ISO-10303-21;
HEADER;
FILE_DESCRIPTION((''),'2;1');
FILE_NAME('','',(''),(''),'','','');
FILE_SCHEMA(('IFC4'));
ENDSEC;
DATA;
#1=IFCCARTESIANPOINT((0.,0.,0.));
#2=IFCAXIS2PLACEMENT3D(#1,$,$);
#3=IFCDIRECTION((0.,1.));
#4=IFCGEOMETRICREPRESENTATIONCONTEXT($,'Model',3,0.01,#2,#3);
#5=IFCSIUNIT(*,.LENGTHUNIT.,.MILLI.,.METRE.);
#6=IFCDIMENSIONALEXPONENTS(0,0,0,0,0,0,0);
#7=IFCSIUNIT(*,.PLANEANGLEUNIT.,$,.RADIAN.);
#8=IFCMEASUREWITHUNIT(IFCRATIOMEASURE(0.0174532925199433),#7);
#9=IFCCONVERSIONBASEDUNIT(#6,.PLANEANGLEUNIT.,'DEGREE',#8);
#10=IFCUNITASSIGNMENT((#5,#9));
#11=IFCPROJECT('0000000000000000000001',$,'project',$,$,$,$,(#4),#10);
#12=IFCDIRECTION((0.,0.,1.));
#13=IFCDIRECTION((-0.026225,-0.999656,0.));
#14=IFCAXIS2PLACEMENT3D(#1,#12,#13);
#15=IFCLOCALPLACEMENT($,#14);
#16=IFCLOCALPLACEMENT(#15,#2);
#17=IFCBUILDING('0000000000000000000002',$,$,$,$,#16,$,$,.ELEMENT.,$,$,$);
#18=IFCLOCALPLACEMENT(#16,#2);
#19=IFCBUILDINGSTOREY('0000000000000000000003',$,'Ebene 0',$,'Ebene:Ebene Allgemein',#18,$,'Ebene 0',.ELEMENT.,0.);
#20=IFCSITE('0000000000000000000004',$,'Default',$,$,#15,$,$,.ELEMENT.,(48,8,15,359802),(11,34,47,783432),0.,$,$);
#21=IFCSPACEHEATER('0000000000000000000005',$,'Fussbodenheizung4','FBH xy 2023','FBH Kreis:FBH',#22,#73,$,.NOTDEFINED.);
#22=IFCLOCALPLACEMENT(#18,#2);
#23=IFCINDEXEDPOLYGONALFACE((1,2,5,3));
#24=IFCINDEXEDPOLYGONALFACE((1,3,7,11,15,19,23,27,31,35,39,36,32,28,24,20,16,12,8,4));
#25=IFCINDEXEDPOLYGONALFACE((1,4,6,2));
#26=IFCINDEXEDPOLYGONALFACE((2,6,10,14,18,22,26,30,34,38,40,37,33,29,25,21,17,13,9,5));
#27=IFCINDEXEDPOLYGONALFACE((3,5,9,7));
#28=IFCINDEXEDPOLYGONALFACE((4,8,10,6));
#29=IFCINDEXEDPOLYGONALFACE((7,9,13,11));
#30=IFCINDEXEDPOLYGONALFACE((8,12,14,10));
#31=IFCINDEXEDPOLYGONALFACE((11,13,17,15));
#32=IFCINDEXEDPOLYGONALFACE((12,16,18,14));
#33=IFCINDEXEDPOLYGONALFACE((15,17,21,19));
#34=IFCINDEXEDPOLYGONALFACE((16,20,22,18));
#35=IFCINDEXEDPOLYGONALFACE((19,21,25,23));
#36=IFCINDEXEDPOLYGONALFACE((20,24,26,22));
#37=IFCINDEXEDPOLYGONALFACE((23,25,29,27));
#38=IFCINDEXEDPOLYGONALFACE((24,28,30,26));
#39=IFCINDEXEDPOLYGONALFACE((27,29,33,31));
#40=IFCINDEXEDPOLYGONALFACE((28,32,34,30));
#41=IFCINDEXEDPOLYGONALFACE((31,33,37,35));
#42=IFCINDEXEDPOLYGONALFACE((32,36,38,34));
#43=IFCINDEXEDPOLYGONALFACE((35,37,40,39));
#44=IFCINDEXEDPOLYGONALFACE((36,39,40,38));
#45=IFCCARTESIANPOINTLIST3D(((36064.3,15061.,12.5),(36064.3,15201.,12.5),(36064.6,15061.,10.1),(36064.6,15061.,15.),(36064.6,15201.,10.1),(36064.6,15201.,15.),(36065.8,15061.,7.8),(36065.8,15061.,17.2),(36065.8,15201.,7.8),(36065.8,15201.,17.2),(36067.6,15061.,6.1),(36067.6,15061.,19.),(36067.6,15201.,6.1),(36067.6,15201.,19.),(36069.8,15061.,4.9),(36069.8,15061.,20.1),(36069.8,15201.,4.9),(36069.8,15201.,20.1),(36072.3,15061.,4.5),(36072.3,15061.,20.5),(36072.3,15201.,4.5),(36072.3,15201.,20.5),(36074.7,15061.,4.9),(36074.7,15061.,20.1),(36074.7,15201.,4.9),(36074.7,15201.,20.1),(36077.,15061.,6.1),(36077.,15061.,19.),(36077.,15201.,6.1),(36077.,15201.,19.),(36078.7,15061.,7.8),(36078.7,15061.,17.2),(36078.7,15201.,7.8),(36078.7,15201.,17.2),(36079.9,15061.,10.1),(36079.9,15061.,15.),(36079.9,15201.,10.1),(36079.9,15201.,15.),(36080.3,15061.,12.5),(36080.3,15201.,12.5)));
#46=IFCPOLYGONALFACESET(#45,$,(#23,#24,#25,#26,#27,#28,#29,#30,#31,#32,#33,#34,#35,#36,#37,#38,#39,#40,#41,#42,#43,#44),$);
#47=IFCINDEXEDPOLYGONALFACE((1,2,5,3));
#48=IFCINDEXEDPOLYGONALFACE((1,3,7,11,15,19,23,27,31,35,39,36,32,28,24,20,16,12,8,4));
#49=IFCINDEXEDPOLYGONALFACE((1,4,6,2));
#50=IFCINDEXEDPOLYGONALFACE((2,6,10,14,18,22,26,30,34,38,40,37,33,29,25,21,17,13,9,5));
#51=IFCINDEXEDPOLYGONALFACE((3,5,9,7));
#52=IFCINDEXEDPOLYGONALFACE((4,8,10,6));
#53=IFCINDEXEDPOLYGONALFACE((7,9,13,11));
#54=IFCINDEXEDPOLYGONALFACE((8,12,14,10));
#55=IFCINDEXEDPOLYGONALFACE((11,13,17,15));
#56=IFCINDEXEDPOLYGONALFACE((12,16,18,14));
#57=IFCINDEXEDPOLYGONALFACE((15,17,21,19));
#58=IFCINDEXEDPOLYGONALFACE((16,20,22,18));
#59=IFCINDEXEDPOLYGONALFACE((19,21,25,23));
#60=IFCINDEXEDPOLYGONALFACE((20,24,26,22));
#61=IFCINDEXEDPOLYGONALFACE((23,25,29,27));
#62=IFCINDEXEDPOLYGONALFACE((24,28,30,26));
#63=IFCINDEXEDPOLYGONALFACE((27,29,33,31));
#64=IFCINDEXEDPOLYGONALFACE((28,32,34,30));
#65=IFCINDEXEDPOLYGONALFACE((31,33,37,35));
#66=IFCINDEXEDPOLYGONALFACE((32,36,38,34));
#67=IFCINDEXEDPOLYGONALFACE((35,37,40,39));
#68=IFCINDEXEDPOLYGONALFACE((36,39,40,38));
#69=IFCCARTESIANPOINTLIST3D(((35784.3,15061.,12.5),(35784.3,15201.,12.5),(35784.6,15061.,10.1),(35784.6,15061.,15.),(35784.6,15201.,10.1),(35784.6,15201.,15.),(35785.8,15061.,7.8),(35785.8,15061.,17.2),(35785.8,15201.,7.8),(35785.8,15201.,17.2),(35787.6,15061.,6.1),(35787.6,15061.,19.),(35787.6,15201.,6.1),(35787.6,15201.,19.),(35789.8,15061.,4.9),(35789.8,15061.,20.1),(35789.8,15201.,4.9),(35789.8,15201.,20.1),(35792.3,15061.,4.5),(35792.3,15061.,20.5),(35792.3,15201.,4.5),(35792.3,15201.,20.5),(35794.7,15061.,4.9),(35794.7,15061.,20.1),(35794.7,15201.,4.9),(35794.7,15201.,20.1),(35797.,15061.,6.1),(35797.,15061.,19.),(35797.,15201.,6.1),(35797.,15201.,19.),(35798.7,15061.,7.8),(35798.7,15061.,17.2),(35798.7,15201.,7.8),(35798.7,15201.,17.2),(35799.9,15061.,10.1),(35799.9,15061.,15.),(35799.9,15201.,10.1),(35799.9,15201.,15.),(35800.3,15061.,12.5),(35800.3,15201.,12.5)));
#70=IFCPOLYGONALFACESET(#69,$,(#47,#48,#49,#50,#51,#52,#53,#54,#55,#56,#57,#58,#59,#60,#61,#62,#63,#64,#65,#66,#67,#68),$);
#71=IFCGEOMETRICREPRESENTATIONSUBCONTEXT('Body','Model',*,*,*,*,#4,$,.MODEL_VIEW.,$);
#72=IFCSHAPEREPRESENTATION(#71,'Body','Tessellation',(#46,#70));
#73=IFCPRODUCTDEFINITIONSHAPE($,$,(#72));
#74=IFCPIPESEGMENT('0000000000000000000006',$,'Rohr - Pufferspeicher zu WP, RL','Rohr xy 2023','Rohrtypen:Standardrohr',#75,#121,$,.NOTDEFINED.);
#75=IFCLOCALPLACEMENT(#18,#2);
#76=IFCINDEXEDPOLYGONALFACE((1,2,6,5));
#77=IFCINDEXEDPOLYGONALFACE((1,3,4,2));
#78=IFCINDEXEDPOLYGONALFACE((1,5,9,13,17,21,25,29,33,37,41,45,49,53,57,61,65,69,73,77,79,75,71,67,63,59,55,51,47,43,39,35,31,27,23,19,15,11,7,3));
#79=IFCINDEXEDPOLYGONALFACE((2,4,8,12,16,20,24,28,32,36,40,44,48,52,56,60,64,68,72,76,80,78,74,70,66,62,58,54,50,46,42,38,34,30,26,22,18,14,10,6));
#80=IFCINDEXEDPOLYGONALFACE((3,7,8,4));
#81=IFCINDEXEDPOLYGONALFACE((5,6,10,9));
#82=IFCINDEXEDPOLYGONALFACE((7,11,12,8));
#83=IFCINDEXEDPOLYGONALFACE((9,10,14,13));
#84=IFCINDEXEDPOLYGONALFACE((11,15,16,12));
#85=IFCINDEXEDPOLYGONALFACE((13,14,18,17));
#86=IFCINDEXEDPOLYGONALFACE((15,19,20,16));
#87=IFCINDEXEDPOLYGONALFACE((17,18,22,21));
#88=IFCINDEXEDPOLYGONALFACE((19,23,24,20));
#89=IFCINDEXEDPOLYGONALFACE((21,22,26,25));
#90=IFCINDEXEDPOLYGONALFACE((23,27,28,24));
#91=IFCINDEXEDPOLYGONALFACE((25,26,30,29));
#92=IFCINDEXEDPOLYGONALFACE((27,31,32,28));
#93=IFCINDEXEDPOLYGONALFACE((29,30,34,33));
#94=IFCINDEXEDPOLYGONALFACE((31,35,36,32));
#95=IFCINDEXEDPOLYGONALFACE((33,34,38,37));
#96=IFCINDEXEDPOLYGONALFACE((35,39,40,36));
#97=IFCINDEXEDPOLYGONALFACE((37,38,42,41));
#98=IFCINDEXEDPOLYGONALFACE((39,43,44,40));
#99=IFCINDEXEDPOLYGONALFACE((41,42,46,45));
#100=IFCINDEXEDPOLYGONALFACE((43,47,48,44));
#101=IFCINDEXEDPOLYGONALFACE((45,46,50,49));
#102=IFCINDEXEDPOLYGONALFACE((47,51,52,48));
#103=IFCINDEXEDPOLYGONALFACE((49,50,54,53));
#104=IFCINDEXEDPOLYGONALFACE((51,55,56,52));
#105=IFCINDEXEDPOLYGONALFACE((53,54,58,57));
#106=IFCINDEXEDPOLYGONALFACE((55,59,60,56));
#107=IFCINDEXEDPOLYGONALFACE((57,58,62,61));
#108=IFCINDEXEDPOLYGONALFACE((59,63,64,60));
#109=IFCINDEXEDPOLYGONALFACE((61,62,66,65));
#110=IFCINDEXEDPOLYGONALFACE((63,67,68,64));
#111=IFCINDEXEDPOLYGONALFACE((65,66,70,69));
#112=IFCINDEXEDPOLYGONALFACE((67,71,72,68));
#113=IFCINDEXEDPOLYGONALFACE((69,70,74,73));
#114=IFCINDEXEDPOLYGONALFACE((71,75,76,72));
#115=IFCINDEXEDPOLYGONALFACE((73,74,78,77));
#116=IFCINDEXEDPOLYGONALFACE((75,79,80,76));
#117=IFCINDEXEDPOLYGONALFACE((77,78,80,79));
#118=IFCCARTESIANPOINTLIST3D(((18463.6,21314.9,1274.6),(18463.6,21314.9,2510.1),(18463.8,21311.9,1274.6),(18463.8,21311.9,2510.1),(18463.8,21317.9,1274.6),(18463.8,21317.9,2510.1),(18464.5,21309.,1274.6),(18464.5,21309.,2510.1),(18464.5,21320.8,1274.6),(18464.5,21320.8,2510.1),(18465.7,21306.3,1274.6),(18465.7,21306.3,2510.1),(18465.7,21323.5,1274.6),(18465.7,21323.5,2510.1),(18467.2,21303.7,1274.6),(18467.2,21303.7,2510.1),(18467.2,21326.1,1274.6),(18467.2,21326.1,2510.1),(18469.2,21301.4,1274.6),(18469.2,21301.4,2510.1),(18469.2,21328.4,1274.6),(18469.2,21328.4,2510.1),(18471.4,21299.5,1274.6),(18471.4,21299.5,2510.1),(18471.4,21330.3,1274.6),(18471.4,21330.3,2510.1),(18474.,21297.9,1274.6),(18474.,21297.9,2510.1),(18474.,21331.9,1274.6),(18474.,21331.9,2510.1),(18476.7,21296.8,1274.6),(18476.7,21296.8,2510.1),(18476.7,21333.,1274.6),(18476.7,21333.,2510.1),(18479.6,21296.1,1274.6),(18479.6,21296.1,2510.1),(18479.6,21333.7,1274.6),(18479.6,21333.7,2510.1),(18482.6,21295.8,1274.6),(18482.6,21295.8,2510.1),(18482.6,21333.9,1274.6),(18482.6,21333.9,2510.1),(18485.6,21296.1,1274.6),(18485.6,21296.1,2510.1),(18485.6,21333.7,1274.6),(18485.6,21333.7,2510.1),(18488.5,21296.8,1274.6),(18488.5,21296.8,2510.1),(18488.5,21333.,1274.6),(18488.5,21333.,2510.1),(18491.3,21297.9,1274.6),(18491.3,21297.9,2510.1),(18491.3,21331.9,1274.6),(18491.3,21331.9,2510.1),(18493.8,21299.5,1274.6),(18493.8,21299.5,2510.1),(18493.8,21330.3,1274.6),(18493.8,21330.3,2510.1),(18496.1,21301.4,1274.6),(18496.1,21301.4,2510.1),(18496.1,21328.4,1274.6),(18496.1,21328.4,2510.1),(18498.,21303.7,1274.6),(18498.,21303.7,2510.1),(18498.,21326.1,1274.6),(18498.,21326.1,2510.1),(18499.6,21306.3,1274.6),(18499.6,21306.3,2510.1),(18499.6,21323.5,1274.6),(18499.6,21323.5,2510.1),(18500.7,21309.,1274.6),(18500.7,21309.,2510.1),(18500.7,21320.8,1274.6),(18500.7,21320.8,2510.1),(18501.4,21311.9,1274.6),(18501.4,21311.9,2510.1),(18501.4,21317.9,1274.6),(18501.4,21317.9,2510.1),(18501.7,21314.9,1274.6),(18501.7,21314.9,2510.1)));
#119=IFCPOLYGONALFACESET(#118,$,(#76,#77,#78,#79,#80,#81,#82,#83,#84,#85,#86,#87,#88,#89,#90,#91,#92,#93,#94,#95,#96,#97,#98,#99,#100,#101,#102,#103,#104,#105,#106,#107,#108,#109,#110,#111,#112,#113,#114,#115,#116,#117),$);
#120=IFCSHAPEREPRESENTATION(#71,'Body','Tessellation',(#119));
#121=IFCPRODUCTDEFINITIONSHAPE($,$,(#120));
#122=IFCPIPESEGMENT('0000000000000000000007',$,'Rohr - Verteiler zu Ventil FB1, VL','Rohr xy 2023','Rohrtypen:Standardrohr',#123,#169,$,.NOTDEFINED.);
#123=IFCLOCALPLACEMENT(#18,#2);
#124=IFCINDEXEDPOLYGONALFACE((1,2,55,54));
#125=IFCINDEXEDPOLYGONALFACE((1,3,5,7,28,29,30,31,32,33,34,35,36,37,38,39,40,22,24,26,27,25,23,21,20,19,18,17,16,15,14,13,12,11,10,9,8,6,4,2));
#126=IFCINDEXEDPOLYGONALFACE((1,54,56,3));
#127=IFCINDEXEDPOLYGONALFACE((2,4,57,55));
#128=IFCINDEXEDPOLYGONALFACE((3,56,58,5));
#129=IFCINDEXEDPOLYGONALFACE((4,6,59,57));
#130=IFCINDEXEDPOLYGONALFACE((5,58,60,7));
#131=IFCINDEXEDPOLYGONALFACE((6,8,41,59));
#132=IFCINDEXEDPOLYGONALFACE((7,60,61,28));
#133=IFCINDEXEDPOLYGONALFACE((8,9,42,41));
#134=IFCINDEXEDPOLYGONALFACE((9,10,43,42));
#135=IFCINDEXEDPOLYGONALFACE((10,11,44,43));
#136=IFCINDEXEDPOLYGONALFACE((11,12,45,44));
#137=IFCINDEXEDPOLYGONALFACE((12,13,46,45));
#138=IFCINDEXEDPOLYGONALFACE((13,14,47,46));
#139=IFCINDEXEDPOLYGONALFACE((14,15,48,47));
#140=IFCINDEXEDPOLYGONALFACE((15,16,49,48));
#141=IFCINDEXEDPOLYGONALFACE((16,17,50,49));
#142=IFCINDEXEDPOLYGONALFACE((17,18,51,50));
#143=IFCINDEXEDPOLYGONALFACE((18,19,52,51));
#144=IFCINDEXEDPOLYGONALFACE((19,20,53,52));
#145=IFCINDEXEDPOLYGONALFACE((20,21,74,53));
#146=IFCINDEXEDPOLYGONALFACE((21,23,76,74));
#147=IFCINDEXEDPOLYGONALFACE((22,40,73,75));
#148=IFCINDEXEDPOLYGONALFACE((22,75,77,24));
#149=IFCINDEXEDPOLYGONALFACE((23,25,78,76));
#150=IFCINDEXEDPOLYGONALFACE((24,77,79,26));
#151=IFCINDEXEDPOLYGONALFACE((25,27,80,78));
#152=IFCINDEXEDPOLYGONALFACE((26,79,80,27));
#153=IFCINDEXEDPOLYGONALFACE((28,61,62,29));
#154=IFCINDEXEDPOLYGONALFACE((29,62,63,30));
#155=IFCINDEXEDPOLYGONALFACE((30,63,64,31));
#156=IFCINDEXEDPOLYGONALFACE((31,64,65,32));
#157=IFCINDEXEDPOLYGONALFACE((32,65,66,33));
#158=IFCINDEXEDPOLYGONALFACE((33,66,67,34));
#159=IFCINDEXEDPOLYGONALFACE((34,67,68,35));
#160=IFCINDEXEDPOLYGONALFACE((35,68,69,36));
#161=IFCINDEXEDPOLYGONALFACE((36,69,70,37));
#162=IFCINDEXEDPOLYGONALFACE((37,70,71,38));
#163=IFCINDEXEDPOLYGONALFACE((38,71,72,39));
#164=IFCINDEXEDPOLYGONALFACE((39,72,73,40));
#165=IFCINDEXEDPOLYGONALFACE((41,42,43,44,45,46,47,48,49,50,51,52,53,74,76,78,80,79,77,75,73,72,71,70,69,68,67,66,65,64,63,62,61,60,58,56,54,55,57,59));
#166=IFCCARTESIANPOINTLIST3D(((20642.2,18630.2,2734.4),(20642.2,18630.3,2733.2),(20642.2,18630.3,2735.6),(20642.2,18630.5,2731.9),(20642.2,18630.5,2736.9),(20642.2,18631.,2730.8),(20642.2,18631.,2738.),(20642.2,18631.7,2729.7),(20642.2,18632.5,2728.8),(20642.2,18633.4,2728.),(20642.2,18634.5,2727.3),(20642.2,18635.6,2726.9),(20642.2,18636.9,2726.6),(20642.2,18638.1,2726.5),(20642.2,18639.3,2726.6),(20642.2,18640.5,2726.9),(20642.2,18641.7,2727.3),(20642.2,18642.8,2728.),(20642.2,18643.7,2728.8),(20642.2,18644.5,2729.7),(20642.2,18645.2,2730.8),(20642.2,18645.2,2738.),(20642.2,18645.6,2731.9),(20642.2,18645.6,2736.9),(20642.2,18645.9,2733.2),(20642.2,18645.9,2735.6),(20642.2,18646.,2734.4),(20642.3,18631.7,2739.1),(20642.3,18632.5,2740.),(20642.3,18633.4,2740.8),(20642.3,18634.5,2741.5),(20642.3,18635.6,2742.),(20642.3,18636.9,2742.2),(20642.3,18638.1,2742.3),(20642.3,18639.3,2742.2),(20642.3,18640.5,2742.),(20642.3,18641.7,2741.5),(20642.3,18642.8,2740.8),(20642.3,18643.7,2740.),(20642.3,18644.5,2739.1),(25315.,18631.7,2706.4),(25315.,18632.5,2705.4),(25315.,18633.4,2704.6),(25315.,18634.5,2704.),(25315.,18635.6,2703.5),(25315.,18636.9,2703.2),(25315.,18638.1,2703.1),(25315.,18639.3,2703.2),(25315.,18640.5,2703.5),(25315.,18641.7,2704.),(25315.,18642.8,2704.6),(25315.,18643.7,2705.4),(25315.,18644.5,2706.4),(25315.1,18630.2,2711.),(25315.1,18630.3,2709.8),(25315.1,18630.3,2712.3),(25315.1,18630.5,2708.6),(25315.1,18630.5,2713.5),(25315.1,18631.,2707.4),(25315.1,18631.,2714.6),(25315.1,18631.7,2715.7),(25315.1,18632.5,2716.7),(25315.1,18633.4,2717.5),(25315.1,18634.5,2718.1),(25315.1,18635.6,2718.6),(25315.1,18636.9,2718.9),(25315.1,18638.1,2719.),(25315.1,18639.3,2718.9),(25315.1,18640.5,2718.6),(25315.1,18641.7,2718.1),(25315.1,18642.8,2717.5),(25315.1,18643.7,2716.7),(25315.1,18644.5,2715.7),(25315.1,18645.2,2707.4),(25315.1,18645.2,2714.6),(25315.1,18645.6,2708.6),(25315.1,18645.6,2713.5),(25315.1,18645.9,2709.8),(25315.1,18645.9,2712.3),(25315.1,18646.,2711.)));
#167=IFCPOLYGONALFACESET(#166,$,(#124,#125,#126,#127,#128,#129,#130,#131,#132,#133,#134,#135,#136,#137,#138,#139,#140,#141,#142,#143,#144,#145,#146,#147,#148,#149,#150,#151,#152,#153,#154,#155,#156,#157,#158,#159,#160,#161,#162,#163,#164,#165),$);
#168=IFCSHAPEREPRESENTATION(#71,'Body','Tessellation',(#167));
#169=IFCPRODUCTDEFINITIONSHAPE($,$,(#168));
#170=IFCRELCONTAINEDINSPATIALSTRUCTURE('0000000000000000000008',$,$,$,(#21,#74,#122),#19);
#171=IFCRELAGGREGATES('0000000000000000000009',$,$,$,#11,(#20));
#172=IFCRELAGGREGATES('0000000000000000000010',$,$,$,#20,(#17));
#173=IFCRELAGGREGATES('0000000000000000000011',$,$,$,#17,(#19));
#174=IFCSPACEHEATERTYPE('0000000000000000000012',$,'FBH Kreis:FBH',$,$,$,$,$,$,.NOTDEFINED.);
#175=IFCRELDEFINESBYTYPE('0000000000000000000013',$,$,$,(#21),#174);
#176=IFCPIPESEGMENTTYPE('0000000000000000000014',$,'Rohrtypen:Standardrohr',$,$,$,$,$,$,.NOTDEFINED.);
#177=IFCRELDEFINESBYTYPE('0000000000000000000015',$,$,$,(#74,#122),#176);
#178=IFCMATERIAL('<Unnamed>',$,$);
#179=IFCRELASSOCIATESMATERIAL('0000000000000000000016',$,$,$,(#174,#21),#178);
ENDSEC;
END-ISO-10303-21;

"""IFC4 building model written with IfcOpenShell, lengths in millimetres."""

from ifc_helpers import new_model, entity, si_unit, converted_unit, direction, frame, origin, place, context, subcontext, project, spatial, indexed_curve, outline, extrude, source, transform, mapped, material, type_object, type_shapes, element, save


model = new_model("IFC4")

# Units and contexts
model_context = context("Model", 3, precision=0.01, world=origin(), true_north=direction((0.0, 1.0)))
body_context = subcontext(model_context, "Body", "Model", "MODEL_VIEW")
ifc_project = project(units=[si_unit("LENGTHUNIT", "METRE", prefix="MILLI"), converted_unit("PLANEANGLEUNIT", "DEGREE", entity("IfcRatioMeasure", 0.0174532925199433), si_unit("PLANEANGLEUNIT", "RADIAN"), dimensions=[0, 0, 0, 0, 0, 0, 0])], contexts=[model_context])

# Site, building, storey
site_placement = place(None, frame((0.0, 0.0, 0.0), z_axis=(0.0, 0.0, 1.0), x_axis=(-0.026225, -0.999656, 0.0)))
site = spatial("IfcSite", under=ifc_project, at=site_placement, Name="Default", CompositionType="ELEMENT", RefLatitude=(48, 8, 15, 359802), RefLongitude=(11, 34, 47, 783432), RefElevation=0.0)
building_placement = place(site_placement, origin())
building = spatial("IfcBuilding", under=site, at=building_placement, CompositionType="ELEMENT")
storey_placement = place(building_placement, origin())
storey = spatial("IfcBuildingStorey", under=building, at=storey_placement, Name="Ebene 0", ObjectType="Ebene:Ebene Allgemein", LongName="Ebene 0", CompositionType="ELEMENT", Elevation=0.0)

# Space heater
ifc_material = material(Name="<Unnamed>")
space_heater_type = type_object("IfcSpaceHeaterType", Name="FBH Kreis:FBH", PredefinedType="NOTDEFINED", material=ifc_material)
shared_shape = source(origin(), body_context, "Body", "SweptSolid", [
    extrude(outline(indexed_curve([(8.0, 0.0), (7.6, 2.5), (6.5, 4.7), (4.7, 6.5), (2.5, 7.6), (0.0, 8.0), (-2.5, 7.6), (-4.7, 6.5), (-6.5, 4.7), (-7.6, 2.5), (-8.0, 0.0), (-7.6, -2.5), (-6.5, -4.7), (-4.7, -6.5), (-2.5, -7.6), (0.0, -8.0), (2.5, -7.6), (4.7, -6.5), (6.5, -4.7), (7.6, -2.5), (8.0, 0.0)], self_intersect=False)), frame((140.0, -1621.8, -83.0), z_axis=(0.0, 1.0, 0.0), x_axis=(1.0, 0.0, 0.0)), (0.0, 0.0, 1.0), 140.0),
    extrude(outline(indexed_curve([(8.0, 0.0), (7.6, 2.5), (6.5, 4.7), (4.7, 6.5), (2.5, 7.6), (0.0, 8.0), (-2.5, 7.6), (-4.7, 6.5), (-6.5, 4.7), (-7.6, 2.5), (-8.0, 0.0), (-7.6, -2.5), (-6.5, -4.7), (-4.7, -6.5), (-2.5, -7.6), (0.0, -8.0), (2.5, -7.6), (4.7, -6.5), (6.5, -4.7), (7.6, -2.5), (8.0, 0.0)], self_intersect=False)), frame((-140.0, -1621.8, -83.0), z_axis=(0.0, 1.0, 0.0), x_axis=(1.0, 0.0, 0.0)), (0.0, 0.0, 1.0), 140.0),
])
type_shapes(space_heater_type, [shared_shape])
for number, where, name in (
    (1, (35932.3, 16682.8, 95.5), "Fussbodenheizung4"),
):
    element("IfcSpaceHeater", number, at=place(storey_placement, frame(where)), inside=storey, type_object=space_heater_type, material=ifc_material, Name=name, Description="FBH xy 2023", ObjectType="FBH Kreis:FBH", PredefinedType="NOTDEFINED", context=body_context, shape_type="MappedRepresentation", body=[
        mapped(shared_shape, transform((0.0, 0.0, 0.0), scale=1.0)),
    ])

# Pipe segments
pipe_segment_type = type_object("IfcPipeSegmentType", Name="Rohrtypen:Standardrohr", PredefinedType="NOTDEFINED")
pipe_segment_1_placement = place(storey_placement, origin())
element("IfcPipeSegment", 2, at=pipe_segment_1_placement, inside=storey, type_object=pipe_segment_type, Name="Rohr - Pufferspeicher zu WP, RL", Description="Rohr xy 2023", ObjectType="Rohrtypen:Standardrohr", PredefinedType="NOTDEFINED", context=body_context, shape_type="SweptSolid", body=[
    extrude(outline(indexed_curve([(19.1, 0.0), (18.8, 3.0), (18.1, 5.9), (17.0, 8.6), (15.4, 11.2), (13.5, 13.5), (11.2, 15.4), (8.6, 17.0), (5.9, 18.1), (3.0, 18.8), (0.0, 19.1), (-3.0, 18.8), (-5.9, 18.1), (-8.6, 17.0), (-11.2, 15.4), (-13.5, 13.5), (-15.4, 11.2), (-17.0, 8.6), (-18.1, 5.9), (-18.8, 3.0), (-19.1, 0.0), (-18.8, -3.0), (-18.1, -5.9), (-17.0, -8.6), (-15.4, -11.2), (-13.5, -13.5), (-11.2, -15.4), (-8.6, -17.0), (-5.9, -18.1), (-3.0, -18.8), (0.0, -19.1), (3.0, -18.8), (5.9, -18.1), (8.6, -17.0), (11.2, -15.4), (13.5, -13.5), (15.4, -11.2), (17.0, -8.6), (18.1, -5.9), (18.8, -3.0), (19.1, 0.0)], self_intersect=False)), frame((18482.6, 21314.9, 1274.6), z_axis=(0.0, 0.0, 1.0), x_axis=(-1.0, 0.0, 0.0)), (0.0, 0.0, 1.0), 1235.5),
])
pipe_segment_2_placement = place(storey_placement, origin())
element("IfcPipeSegment", 3, at=pipe_segment_2_placement, inside=storey, type_object=pipe_segment_type, Name="Rohr - Verteiler zu Ventil FB1, VL", Description="Rohr xy 2023", ObjectType="Rohrtypen:Standardrohr", PredefinedType="NOTDEFINED", context=body_context, shape_type="SweptSolid", body=[
    extrude(outline(indexed_curve([(7.9, 0.0), (7.8, 1.2), (7.6, 2.5), (7.1, 3.6), (6.4, 4.7), (5.6, 5.6), (4.7, 6.4), (3.6, 7.1), (2.5, 7.6), (1.2, 7.8), (0.0, 7.9), (-1.2, 7.8), (-2.5, 7.6), (-3.6, 7.1), (-4.7, 6.4), (-5.6, 5.6), (-6.4, 4.7), (-7.1, 3.6), (-7.6, 2.5), (-7.8, 1.2), (-7.9, 0.0), (-7.8, -1.2), (-7.6, -2.5), (-7.1, -3.6), (-6.4, -4.7), (-5.6, -5.6), (-4.7, -6.4), (-3.6, -7.1), (-2.5, -7.6), (-1.2, -7.8), (0.0, -7.9), (1.2, -7.8), (2.5, -7.6), (3.6, -7.1), (4.7, -6.4), (5.6, -5.6), (6.4, -4.7), (7.1, -3.6), (7.6, -2.5), (7.8, -1.2), (7.9, 0.0)], self_intersect=False)), frame((25315.1, 18638.1, 2711.0), z_axis=(-0.999988, 0.0, 0.005), x_axis=(0.0, 1.0, 0.0)), (0.0, 0.0, 1.0), 4672.9),
])

save(model, "model.ifc")
